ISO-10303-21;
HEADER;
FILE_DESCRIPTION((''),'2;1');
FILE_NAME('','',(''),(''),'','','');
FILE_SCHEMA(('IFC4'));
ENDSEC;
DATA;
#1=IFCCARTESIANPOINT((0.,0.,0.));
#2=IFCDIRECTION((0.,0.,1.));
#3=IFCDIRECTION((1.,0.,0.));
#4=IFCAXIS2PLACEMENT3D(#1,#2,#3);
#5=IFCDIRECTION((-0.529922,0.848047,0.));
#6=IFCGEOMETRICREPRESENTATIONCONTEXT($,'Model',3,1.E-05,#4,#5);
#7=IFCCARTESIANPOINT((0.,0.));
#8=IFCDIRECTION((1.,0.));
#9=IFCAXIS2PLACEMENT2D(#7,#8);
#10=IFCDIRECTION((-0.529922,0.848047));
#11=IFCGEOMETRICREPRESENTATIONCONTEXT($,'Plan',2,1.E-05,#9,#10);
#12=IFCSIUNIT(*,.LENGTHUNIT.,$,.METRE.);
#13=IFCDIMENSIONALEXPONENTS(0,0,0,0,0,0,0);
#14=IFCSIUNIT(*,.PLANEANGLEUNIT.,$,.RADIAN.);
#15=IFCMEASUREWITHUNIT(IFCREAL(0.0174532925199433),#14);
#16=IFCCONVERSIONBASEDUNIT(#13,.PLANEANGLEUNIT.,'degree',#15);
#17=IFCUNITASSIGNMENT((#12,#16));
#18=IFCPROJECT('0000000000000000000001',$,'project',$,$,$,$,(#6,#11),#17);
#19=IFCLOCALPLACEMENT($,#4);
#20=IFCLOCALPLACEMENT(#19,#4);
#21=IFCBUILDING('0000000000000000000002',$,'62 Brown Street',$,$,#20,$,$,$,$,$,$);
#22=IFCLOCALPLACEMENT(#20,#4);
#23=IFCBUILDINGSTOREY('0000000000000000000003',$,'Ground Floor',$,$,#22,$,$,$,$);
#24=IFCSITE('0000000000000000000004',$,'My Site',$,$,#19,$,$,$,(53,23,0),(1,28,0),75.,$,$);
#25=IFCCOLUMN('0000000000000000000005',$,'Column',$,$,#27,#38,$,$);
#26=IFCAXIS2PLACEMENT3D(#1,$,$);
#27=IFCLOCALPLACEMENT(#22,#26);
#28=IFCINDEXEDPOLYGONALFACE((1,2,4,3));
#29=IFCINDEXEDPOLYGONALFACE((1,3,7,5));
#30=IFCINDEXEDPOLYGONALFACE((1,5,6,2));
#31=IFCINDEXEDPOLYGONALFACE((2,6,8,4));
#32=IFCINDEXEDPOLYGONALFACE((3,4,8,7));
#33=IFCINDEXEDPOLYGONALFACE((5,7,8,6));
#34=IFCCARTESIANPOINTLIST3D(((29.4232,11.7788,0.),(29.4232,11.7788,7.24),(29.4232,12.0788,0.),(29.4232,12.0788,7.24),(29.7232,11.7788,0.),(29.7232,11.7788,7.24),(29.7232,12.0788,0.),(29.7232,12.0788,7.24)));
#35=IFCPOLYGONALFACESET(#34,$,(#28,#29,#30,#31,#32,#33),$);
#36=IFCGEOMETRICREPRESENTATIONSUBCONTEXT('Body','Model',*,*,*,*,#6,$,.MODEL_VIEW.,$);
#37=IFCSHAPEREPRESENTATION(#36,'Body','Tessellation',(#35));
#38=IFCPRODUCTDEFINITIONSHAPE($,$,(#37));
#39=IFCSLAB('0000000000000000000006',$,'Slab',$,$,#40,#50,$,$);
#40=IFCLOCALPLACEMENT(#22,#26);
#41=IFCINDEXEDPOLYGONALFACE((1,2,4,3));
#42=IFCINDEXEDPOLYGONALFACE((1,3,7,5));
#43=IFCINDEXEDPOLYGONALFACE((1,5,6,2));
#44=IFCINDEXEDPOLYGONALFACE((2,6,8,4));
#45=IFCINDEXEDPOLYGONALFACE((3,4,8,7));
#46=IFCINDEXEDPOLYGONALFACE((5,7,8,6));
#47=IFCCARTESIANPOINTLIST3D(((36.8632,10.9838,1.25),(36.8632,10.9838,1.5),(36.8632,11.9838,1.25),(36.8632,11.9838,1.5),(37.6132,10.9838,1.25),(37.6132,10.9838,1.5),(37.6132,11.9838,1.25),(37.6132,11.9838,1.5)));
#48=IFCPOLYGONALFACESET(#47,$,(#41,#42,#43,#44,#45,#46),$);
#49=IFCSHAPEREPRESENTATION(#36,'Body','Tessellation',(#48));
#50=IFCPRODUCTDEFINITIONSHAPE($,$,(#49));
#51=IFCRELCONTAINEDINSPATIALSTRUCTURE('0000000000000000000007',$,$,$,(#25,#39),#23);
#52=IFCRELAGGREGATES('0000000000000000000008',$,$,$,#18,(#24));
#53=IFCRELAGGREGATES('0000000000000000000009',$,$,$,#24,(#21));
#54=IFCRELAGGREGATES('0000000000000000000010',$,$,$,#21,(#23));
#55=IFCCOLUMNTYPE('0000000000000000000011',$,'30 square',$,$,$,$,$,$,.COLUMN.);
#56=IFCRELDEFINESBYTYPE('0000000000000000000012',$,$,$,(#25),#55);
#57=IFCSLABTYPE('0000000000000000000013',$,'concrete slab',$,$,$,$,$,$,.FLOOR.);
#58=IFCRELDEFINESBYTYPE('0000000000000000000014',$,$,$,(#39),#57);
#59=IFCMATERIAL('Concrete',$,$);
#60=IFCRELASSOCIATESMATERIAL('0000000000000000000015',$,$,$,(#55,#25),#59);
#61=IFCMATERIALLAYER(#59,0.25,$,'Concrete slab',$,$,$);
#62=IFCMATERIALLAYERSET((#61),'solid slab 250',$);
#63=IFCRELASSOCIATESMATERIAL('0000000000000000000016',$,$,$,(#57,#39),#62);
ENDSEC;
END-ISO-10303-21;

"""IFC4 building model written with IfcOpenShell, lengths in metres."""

from ifc_helpers import new_model, entity, si_unit, converted_unit, direction, frame, origin_with_axes, origin_2d_with_axis, place, context, subcontext, project, spatial, line, indexed_curve, rectangle, outline, extrude, material, layer, layer_set, layer_usage, material_profile, profile_set, profile_usage, type_object, element, save


model = new_model("IFC4")

# Units and contexts
model_context = context("Model", 3, precision=1e-05, world=origin_with_axes(), true_north=direction((-0.529922, 0.848047, 0.0)))
plan_context = context("Plan", 2, precision=1e-05, world=origin_2d_with_axis(), true_north=direction((-0.529922, 0.848047)))
body_context_1 = subcontext(model_context, "Body", "Model", "MODEL_VIEW")
ifc_project = project(units=[si_unit("LENGTHUNIT", "METRE"), converted_unit("PLANEANGLEUNIT", "degree", entity("IfcReal", 0.0174532925199433), si_unit("PLANEANGLEUNIT", "RADIAN"), dimensions=[0, 0, 0, 0, 0, 0, 0])], contexts=[model_context, plan_context])

# Site, building, storey
site_placement = place(None, origin_with_axes())
site = spatial("IfcSite", under=ifc_project, at=site_placement, Name="My Site", RefLatitude=(53, 23, 0), RefLongitude=(1, 28, 0), RefElevation=75.0)
building_placement = place(site_placement, origin_with_axes())
building = spatial("IfcBuilding", under=site, at=building_placement, Name="62 Brown Street")
storey_placement = place(building_placement, origin_with_axes())
storey = spatial("IfcBuildingStorey", under=building, at=storey_placement, Name="Ground Floor")

# Column
ifc_material_1 = material(Name="Concrete")
ifc_material_profile_1 = material_profile(ifc_material_1, rectangle(XDim=0.3, YDim=0.3))
ifc_profile_set_1 = profile_set([ifc_material_profile_1])
ifc_profile_usage_1 = profile_usage(ifc_profile_set_1, cardinal=5)
column_type = type_object("IfcColumnType", Name="30 square", PredefinedType="COLUMN", material=ifc_profile_set_1)
column_placement = place(storey_placement, frame((29.5732, 11.9288, 0.0), z_axis=(0.0, 0.0, 1.0), x_axis=(1.0, 0.0, 0.0)))
element("IfcColumn", 1, at=column_placement, inside=storey, type_object=column_type, material=ifc_profile_usage_1, Name="Column", context=body_context_1, shape_type="SweptSolid", body=[
    extrude(rectangle(XDim=0.3, YDim=0.3), origin_with_axes(), (0.0, 0.0, 1.0), 7.24),
])

# Slab
ifc_layer_1 = layer(ifc_material_1, 0.25, Name="Concrete slab")
ifc_layer_set_1 = layer_set([ifc_layer_1], Name="solid slab 250")
ifc_layer_usage_1 = layer_usage(ifc_layer_set_1, "AXIS3", "POSITIVE", 0.0)
slab_type = type_object("IfcSlabType", Name="concrete slab", PredefinedType="FLOOR", material=ifc_layer_set_1)
slab_placement = place(storey_placement, frame((36.8632, 10.9838, 1.25), z_axis=(0.0, 0.0, 1.0), x_axis=(1.0, 0.0, 0.0)))
element("IfcSlab", 2, at=slab_placement, inside=storey, type_object=slab_type, material=ifc_layer_usage_1, Name="Slab", context=body_context_1, shape_type="SweptSolid", body=[
    extrude(outline(indexed_curve([(0.0, 0.0), (0.75, 0.0), (0.75, 1.0), (0.0, 1.0)], segments=[line(4, 1), line(1, 2), line(2, 3), line(3, 4)], self_intersect=False)), None, (0.0, 0.0, 1.0), 0.25),
])

save(model, "model.ifc")
